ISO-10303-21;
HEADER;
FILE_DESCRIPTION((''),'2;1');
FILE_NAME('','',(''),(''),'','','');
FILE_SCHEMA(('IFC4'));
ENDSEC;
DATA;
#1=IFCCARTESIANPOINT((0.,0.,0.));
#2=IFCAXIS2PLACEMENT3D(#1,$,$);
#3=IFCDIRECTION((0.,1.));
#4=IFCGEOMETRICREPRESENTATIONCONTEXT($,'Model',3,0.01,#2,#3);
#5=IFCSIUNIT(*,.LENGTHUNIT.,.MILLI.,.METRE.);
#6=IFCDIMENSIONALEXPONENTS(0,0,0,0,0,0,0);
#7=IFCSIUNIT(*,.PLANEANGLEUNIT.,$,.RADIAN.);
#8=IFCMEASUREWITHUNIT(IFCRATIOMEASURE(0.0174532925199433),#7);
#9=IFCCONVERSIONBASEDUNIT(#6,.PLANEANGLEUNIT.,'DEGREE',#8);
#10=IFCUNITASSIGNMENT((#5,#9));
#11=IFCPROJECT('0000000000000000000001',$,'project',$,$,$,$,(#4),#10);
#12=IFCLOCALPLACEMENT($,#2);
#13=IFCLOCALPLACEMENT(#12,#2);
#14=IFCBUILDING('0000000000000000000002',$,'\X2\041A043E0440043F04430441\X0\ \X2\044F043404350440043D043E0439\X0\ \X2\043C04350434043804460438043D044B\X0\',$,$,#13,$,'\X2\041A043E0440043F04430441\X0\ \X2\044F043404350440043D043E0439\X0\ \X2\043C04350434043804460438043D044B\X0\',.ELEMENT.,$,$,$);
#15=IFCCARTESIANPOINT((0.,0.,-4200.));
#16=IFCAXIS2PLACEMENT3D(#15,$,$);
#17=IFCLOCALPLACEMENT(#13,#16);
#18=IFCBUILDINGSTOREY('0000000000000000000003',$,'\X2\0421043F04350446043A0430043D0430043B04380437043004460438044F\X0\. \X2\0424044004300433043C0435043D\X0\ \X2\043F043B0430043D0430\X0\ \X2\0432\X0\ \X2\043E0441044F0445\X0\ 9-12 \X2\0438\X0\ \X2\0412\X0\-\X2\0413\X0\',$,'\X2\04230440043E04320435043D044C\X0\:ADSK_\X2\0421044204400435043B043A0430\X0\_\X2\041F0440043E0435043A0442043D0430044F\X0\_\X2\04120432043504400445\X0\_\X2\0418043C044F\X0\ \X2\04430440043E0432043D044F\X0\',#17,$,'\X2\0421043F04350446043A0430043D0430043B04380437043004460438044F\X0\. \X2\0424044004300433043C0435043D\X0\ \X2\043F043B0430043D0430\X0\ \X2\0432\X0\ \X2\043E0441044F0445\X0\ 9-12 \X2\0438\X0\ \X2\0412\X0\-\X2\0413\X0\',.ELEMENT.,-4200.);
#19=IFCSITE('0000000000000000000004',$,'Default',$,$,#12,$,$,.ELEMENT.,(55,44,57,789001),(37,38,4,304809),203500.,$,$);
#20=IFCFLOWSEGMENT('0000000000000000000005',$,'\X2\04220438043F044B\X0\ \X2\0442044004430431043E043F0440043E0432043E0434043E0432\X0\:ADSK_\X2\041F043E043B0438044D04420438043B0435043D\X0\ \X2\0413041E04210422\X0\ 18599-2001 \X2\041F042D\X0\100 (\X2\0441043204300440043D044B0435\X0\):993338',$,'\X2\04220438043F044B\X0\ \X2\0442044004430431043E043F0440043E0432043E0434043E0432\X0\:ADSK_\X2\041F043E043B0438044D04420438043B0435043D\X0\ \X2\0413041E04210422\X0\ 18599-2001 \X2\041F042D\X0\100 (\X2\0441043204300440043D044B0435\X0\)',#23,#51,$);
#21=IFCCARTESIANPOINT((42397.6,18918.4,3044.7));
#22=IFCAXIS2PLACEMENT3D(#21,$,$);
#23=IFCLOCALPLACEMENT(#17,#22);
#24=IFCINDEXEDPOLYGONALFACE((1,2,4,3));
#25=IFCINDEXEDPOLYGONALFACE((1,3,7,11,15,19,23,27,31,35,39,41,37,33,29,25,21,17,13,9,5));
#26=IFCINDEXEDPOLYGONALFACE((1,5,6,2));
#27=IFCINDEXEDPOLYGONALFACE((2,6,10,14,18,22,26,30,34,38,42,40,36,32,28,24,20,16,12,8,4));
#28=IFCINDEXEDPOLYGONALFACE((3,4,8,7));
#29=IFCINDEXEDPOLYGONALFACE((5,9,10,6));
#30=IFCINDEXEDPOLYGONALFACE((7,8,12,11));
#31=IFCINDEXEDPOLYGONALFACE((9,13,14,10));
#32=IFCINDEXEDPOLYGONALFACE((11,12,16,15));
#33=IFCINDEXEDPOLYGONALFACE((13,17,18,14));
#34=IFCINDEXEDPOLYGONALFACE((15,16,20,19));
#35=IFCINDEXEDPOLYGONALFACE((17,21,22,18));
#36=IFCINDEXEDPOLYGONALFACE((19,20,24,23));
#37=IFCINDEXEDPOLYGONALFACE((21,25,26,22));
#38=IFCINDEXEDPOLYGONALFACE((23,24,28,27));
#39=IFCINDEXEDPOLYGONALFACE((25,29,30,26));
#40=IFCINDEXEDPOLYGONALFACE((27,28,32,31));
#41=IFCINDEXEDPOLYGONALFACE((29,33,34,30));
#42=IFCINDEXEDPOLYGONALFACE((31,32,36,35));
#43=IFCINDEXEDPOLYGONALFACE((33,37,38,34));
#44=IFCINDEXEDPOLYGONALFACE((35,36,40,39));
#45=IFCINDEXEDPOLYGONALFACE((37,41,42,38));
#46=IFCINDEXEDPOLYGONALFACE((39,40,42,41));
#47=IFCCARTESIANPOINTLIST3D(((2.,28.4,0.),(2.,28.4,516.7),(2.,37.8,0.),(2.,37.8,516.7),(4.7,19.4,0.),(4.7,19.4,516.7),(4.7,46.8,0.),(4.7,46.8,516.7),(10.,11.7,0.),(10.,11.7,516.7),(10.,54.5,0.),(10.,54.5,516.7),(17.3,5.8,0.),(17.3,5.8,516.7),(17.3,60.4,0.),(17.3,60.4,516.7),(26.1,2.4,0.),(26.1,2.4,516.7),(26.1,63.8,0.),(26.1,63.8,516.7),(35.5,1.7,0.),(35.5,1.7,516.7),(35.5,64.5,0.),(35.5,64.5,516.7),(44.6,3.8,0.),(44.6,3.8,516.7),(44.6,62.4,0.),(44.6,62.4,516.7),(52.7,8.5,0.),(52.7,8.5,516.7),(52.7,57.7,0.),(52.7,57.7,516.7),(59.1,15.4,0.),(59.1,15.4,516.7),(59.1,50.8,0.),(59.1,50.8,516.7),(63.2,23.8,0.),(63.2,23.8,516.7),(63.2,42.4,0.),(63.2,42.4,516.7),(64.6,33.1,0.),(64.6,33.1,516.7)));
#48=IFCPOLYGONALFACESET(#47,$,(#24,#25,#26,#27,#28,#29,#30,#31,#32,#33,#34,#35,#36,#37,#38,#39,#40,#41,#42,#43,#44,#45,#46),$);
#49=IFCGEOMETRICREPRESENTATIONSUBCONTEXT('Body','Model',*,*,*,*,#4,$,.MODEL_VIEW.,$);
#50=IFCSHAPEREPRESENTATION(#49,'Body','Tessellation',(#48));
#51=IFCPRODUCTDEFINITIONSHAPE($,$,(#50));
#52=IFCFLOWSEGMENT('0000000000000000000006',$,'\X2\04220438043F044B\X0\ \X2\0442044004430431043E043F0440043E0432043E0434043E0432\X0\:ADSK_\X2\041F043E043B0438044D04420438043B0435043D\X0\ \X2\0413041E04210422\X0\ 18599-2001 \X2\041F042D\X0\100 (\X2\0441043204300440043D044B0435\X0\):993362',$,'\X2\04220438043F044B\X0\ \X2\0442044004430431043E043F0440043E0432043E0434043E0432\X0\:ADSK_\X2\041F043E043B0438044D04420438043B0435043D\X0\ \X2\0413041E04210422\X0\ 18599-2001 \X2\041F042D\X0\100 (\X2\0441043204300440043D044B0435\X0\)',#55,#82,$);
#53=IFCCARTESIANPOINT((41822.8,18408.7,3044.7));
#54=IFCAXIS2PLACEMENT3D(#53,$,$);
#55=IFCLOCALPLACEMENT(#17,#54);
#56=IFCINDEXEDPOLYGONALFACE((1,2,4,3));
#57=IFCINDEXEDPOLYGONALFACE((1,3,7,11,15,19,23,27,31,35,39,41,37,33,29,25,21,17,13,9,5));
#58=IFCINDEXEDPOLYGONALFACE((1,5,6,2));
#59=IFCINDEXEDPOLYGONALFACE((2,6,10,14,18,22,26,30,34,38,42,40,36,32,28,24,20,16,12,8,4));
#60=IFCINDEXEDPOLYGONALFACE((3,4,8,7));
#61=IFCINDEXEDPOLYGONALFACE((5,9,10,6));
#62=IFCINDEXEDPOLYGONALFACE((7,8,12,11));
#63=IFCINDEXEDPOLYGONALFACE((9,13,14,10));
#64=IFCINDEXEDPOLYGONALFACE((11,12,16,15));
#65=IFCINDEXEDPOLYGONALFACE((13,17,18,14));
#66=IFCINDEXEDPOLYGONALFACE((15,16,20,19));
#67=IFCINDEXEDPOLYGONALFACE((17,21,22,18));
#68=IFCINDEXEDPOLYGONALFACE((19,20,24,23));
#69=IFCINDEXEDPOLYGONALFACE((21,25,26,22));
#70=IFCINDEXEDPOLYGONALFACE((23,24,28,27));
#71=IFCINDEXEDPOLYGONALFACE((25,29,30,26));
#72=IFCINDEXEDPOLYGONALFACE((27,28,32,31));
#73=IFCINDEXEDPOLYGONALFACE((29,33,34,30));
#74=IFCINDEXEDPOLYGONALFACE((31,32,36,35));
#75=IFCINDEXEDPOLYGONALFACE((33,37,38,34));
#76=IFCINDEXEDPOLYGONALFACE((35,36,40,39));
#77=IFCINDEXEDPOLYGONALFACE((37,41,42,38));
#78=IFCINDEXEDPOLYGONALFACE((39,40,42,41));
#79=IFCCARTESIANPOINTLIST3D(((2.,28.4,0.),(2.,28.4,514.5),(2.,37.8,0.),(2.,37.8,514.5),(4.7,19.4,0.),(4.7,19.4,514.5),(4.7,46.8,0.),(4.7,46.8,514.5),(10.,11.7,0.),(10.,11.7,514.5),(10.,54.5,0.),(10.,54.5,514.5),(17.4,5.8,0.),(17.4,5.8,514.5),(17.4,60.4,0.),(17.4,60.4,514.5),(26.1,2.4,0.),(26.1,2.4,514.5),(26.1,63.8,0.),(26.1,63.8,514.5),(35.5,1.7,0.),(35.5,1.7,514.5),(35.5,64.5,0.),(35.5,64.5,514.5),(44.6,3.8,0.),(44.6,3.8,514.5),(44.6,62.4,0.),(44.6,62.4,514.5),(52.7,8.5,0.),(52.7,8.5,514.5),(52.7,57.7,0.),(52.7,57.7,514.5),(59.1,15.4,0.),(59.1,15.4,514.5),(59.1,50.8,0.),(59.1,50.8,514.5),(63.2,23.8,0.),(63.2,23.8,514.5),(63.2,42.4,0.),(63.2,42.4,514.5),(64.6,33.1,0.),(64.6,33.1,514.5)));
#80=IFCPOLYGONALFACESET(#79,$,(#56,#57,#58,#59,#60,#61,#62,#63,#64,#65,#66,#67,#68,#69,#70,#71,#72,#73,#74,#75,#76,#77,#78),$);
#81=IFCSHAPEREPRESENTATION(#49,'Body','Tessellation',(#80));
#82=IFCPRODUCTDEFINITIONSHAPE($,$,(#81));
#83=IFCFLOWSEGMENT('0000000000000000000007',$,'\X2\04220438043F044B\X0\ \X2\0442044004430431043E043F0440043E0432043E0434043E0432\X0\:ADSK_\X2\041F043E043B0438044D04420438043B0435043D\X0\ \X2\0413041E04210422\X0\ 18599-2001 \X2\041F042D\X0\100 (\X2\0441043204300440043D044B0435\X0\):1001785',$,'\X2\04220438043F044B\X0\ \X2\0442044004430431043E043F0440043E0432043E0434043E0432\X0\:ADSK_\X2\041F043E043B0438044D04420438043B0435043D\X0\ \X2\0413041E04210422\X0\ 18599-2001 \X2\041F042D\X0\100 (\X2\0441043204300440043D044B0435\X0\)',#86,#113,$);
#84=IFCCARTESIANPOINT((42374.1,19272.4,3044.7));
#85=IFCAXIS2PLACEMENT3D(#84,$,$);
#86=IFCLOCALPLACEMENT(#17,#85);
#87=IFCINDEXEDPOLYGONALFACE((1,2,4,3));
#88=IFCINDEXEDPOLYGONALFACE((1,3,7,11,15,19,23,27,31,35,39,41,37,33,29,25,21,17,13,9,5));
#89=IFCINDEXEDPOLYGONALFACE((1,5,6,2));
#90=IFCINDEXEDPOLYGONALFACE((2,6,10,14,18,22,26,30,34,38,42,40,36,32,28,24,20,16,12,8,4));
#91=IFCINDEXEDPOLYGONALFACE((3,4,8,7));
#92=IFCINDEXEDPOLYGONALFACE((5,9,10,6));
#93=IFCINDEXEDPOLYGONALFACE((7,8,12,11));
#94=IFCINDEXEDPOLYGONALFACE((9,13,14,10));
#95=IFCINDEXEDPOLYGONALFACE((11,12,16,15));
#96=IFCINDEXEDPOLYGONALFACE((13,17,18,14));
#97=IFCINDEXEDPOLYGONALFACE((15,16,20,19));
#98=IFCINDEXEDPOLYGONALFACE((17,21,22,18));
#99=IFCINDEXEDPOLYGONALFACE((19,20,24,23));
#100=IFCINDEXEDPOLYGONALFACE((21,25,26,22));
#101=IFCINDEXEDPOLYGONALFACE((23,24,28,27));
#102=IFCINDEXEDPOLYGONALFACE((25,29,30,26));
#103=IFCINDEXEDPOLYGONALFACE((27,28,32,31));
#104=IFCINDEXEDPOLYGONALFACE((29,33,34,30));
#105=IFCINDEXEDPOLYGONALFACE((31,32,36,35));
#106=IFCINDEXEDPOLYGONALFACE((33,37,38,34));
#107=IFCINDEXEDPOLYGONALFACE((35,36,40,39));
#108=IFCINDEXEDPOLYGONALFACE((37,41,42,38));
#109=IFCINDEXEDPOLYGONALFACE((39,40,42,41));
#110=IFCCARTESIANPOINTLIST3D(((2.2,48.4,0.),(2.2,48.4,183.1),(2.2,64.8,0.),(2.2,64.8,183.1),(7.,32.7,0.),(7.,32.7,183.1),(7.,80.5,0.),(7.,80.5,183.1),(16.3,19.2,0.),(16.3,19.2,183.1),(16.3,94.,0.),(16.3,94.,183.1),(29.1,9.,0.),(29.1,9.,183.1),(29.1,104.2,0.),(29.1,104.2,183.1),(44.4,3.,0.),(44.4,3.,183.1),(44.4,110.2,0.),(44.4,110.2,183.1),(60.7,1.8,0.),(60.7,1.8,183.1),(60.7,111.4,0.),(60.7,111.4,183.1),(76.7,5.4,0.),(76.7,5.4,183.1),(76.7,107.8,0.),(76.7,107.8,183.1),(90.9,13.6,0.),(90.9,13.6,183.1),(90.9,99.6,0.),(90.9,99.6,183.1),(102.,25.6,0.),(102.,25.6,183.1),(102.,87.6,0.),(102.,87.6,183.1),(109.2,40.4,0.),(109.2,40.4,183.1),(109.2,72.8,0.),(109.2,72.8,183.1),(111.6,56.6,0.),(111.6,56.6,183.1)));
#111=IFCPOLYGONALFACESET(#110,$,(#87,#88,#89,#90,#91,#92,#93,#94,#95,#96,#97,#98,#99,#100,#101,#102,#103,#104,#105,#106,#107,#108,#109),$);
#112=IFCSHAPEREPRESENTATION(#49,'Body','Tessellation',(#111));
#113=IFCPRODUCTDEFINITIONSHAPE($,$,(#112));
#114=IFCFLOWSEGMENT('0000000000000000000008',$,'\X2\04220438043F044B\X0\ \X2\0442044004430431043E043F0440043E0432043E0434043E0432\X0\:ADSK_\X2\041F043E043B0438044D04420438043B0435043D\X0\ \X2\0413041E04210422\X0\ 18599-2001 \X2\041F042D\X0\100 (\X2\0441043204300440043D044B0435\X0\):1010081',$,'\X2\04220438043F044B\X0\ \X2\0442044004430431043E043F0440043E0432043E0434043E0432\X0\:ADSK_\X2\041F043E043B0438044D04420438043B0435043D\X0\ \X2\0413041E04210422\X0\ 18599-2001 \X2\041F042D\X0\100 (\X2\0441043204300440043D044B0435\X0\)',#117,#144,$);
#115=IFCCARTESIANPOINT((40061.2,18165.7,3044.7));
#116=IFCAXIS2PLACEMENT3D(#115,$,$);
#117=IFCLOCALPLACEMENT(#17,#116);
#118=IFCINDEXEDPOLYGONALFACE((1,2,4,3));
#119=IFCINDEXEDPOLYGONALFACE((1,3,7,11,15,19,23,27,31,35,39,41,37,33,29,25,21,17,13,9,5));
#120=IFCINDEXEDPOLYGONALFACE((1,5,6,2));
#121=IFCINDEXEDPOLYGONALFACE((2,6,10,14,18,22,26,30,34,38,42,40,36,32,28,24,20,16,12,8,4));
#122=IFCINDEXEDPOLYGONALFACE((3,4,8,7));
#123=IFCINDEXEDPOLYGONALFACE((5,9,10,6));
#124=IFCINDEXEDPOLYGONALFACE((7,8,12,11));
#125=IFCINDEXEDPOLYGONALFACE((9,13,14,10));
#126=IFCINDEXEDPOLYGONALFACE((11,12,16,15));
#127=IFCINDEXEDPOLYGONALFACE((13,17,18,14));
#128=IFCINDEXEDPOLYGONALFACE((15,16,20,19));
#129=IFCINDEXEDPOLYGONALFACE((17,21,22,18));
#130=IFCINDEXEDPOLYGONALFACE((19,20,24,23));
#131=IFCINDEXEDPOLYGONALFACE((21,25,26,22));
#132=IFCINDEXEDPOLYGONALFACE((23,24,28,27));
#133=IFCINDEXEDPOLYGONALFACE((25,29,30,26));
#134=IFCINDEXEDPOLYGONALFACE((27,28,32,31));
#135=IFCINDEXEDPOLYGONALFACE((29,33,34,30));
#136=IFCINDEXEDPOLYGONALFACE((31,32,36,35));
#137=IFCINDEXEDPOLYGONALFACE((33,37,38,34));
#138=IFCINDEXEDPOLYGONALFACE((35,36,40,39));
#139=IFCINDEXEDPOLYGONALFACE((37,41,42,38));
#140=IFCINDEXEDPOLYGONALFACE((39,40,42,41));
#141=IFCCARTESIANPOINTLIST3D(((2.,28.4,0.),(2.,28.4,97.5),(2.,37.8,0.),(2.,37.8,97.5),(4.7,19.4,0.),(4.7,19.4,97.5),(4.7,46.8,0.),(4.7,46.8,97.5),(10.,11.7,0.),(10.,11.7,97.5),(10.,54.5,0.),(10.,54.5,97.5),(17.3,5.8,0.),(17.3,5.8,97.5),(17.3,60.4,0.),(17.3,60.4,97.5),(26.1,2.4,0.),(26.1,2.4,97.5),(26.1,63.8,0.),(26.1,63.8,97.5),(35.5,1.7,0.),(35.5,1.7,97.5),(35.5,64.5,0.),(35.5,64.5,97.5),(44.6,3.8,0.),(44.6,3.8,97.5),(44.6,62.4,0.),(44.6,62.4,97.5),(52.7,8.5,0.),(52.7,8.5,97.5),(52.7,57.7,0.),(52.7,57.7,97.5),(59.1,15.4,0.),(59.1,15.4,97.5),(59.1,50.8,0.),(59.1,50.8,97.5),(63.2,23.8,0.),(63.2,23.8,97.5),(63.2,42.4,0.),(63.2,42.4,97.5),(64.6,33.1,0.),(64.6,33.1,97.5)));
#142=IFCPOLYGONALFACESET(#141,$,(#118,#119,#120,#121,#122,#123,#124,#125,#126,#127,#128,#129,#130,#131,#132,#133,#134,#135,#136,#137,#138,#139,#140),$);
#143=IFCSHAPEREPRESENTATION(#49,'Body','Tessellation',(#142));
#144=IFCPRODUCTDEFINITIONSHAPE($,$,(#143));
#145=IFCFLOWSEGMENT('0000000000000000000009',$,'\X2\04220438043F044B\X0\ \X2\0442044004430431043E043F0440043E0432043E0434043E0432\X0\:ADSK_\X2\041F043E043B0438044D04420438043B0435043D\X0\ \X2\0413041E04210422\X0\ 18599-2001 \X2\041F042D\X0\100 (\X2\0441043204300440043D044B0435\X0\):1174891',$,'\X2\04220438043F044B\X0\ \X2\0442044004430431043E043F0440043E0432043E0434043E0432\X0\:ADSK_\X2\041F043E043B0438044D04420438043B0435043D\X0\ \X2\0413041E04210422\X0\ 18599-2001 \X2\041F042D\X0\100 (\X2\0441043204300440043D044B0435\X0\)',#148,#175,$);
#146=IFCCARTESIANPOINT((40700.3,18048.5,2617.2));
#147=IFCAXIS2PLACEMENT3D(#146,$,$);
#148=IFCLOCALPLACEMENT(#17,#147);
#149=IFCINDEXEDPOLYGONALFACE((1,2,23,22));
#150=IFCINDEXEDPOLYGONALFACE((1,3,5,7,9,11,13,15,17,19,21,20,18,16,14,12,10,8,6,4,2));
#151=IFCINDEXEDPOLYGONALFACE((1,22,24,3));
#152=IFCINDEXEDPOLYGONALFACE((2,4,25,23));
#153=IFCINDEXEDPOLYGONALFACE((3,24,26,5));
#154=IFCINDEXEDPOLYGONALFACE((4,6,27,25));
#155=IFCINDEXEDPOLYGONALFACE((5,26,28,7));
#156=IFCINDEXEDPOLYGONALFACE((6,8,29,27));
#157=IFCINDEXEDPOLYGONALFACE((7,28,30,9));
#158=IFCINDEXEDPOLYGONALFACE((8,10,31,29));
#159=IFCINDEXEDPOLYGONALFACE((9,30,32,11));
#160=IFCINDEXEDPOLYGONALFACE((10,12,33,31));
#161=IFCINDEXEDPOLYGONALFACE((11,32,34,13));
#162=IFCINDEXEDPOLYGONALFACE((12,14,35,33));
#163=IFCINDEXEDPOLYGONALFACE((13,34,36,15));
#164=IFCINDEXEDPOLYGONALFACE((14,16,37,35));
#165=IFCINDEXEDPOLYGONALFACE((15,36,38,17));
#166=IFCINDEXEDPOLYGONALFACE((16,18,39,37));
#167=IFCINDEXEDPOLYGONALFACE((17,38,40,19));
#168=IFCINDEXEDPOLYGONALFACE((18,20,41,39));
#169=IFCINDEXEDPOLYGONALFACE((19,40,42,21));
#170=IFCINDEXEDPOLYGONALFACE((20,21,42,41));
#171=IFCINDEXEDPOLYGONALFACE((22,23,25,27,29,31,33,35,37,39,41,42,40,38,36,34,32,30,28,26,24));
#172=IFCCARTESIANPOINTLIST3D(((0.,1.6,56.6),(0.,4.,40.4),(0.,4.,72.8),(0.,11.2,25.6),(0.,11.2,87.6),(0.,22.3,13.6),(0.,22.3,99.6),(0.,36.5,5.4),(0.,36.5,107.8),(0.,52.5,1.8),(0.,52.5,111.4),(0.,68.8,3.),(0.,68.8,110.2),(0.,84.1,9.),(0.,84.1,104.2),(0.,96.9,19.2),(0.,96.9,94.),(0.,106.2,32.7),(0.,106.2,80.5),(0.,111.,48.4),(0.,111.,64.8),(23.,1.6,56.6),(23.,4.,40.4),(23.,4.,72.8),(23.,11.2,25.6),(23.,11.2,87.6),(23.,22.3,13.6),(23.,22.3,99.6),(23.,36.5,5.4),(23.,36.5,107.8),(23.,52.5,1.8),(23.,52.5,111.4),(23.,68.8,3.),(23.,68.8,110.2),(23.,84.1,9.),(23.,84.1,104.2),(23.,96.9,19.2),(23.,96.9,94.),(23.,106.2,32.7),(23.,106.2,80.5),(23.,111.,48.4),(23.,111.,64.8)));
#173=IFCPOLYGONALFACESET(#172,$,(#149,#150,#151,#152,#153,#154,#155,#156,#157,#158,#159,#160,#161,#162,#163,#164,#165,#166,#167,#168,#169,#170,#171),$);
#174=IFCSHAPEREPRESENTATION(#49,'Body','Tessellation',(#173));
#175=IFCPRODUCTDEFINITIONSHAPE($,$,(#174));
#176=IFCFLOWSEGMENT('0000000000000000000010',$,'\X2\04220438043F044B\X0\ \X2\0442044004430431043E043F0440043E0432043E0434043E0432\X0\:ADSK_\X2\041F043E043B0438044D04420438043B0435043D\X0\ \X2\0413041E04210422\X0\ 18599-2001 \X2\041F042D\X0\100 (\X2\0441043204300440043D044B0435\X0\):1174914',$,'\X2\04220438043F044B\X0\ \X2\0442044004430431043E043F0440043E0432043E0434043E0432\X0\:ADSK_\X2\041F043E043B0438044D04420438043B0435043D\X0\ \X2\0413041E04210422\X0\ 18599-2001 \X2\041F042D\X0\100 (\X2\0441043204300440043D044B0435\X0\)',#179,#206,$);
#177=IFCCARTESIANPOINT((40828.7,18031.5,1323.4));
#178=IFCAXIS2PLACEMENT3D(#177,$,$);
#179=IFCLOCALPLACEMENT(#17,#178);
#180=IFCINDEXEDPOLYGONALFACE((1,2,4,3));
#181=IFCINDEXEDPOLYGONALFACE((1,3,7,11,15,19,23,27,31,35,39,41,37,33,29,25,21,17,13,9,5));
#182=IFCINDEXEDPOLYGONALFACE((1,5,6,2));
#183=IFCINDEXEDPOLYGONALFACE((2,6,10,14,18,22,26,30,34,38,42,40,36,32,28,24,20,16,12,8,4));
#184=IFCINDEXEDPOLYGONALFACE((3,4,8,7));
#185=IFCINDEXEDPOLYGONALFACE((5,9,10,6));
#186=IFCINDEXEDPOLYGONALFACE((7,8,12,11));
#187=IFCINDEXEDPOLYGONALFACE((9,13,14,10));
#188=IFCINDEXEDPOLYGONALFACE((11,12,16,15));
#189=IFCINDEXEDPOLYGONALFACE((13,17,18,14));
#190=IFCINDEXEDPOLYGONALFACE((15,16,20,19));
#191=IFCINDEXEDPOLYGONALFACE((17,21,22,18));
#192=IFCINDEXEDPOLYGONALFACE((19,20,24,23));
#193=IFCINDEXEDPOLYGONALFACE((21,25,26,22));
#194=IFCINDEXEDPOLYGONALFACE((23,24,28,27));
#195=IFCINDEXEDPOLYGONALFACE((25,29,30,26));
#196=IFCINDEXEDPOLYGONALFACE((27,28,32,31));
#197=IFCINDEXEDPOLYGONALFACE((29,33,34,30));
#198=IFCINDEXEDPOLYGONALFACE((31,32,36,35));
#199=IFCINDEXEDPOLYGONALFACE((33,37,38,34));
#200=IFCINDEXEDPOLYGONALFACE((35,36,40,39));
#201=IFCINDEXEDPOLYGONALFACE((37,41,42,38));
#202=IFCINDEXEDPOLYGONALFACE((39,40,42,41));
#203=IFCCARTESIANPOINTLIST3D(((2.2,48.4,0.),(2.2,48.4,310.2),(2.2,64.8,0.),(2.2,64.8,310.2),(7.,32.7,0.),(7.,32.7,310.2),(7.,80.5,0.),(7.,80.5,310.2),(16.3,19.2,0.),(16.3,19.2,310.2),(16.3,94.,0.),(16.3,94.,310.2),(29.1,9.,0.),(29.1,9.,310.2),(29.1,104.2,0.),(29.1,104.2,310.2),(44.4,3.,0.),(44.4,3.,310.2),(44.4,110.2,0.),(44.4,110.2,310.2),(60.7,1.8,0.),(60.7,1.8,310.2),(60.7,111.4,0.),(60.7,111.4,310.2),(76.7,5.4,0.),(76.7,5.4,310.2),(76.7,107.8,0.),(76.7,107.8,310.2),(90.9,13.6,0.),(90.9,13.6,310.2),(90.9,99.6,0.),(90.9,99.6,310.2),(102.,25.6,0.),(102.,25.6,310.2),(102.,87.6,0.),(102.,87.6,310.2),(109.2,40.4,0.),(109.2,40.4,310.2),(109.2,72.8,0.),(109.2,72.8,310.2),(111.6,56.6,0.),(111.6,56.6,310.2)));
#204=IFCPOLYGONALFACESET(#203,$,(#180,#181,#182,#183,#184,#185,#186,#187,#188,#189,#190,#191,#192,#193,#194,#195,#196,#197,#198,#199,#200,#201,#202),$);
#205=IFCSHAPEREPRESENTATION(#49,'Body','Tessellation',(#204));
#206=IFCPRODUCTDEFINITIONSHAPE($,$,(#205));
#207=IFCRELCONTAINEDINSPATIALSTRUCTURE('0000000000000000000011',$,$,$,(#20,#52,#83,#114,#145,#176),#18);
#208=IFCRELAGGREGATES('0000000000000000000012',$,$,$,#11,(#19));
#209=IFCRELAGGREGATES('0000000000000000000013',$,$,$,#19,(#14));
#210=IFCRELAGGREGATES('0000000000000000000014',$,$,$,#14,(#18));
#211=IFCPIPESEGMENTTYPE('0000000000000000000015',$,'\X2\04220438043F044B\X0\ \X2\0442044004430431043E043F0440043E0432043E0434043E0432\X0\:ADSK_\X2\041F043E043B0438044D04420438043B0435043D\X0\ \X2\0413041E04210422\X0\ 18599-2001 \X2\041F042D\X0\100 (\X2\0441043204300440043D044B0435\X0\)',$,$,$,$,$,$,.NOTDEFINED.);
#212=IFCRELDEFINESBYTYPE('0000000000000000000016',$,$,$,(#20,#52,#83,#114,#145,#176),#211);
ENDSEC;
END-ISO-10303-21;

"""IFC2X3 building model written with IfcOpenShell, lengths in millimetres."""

from ifc_helpers import new_model, entity, si_unit, converted_unit, direction, frame, origin, origin_2d_with_axis, place, context, subcontext, project, spatial, circle, extrude, type_object, element, save


model = new_model("IFC2X3")

# Units and contexts
model_context = context("Model", 3, precision=0.01, world=origin(), true_north=direction((0.0, 1.0)))
body_context = subcontext(model_context, "Body", "Model", "MODEL_VIEW")
ifc_project = project(units=[si_unit("LENGTHUNIT", "METRE", prefix="MILLI"), converted_unit("PLANEANGLEUNIT", "DEGREE", entity("IfcRatioMeasure", 0.0174532925199433), si_unit("PLANEANGLEUNIT", "RADIAN"), dimensions=[0, 0, 0, 0, 0, 0, 0])], contexts=[model_context])

# Site, building, storey
site_placement = place(None, origin())
site = spatial("IfcSite", under=ifc_project, at=site_placement, Name="Default", CompositionType="ELEMENT", RefLatitude=(55, 44, 57, 789001), RefLongitude=(37, 38, 4, 304809), RefElevation=203500.0)
building_placement = place(site_placement, origin())
building = spatial("IfcBuilding", under=site, at=building_placement, Name="Корпус ядерной медицины", LongName="Корпус ядерной медицины", CompositionType="ELEMENT")
storey_placement = place(building_placement, frame((0.0, 0.0, -4200.0)))
storey = spatial("IfcBuildingStorey", under=building, at=storey_placement, Name="Спецканализация. Фрагмен плана в осях 9-12 и В-Г", ObjectType="Уровень:ADSK_Стрелка_Проектная_Вверх_Имя уровня", LongName="Спецканализация. Фрагмен плана в осях 9-12 и В-Г", CompositionType="ELEMENT", Elevation=-4200.0)

# Flow segments
pipe_segment_type = type_object("IfcPipeSegmentType", Name="Типы трубопроводов:ADSK_Полиэтилен ГОСТ 18599-2001 ПЭ100 (сварные)", PredefinedType="NOTDEFINED")
flow_segment_1_placement = place(storey_placement, frame((42397.6, 18918.4, 3044.7)))
element("IfcFlowSegment", 1, at=flow_segment_1_placement, inside=storey, type_object=pipe_segment_type, Name="Типы трубопроводов:ADSK_Полиэтилен ГОСТ 18599-2001 ПЭ100 (сварные):993338", ObjectType="Типы трубопроводов:ADSK_Полиэтилен ГОСТ 18599-2001 ПЭ100 (сварные)", context=body_context, shape_type="SweptSolid", body=[
    extrude(circle(Radius=31.5, at=origin_2d_with_axis()), frame((33.1, 33.1, 0.0)), (0.0, 0.0, 1.0), 516.7),
])
flow_segment_2_placement = place(storey_placement, frame((41822.8, 18408.7, 3044.7)))
element("IfcFlowSegment", 2, at=flow_segment_2_placement, inside=storey, type_object=pipe_segment_type, Name="Типы трубопроводов:ADSK_Полиэтилен ГОСТ 18599-2001 ПЭ100 (сварные):993362", ObjectType="Типы трубопроводов:ADSK_Полиэтилен ГОСТ 18599-2001 ПЭ100 (сварные)", context=body_context, shape_type="SweptSolid", body=[
    extrude(circle(Radius=31.5, at=origin_2d_with_axis()), frame((33.1, 33.1, 0.0)), (0.0, 0.0, 1.0), 514.5),
])
flow_segment_3_placement = place(storey_placement, frame((42374.1, 19272.4, 3044.7)))
element("IfcFlowSegment", 3, at=flow_segment_3_placement, inside=storey, type_object=pipe_segment_type, Name="Типы трубопроводов:ADSK_Полиэтилен ГОСТ 18599-2001 ПЭ100 (сварные):1001785", ObjectType="Типы трубопроводов:ADSK_Полиэтилен ГОСТ 18599-2001 ПЭ100 (сварные)", context=body_context, shape_type="SweptSolid", body=[
    extrude(circle(Radius=55.0, at=origin_2d_with_axis()), frame((56.6, 56.6, 0.0)), (0.0, 0.0, 1.0), 183.1),
])
flow_segment_4_placement = place(storey_placement, frame((40061.2, 18165.7, 3044.7)))
element("IfcFlowSegment", 4, at=flow_segment_4_placement, inside=storey, type_object=pipe_segment_type, Name="Типы трубопроводов:ADSK_Полиэтилен ГОСТ 18599-2001 ПЭ100 (сварные):1010081", ObjectType="Типы трубопроводов:ADSK_Полиэтилен ГОСТ 18599-2001 ПЭ100 (сварные)", context=body_context, shape_type="SweptSolid", body=[
    extrude(circle(Radius=31.5, at=origin_2d_with_axis()), frame((33.1, 33.1, 0.0)), (0.0, 0.0, 1.0), 97.5),
])
flow_segment_5_placement = place(storey_placement, frame((40700.3, 18048.5, 2617.2)))
element("IfcFlowSegment", 5, at=flow_segment_5_placement, inside=storey, type_object=pipe_segment_type, Name="Типы трубопроводов:ADSK_Полиэтилен ГОСТ 18599-2001 ПЭ100 (сварные):1174891", ObjectType="Типы трубопроводов:ADSK_Полиэтилен ГОСТ 18599-2001 ПЭ100 (сварные)", context=body_context, shape_type="SweptSolid", body=[
    extrude(circle(Radius=55.0, at=origin_2d_with_axis()), frame((0.0, 56.6, 56.6), z_axis=(1.0, 0.0, 0.0), x_axis=(0.0, -1.0, 0.0)), (0.0, 0.0, 1.0), 23.0),
])
flow_segment_6_placement = place(storey_placement, frame((40828.7, 18031.5, 1323.4)))
element("IfcFlowSegment", 6, at=flow_segment_6_placement, inside=storey, type_object=pipe_segment_type, Name="Типы трубопроводов:ADSK_Полиэтилен ГОСТ 18599-2001 ПЭ100 (сварные):1174914", ObjectType="Типы трубопроводов:ADSK_Полиэтилен ГОСТ 18599-2001 ПЭ100 (сварные)", context=body_context, shape_type="SweptSolid", body=[
    extrude(circle(Radius=55.0, at=origin_2d_with_axis()), frame((56.6, 56.6, 0.0)), (0.0, 0.0, 1.0), 310.2),
])

save(model, "model.ifc")
